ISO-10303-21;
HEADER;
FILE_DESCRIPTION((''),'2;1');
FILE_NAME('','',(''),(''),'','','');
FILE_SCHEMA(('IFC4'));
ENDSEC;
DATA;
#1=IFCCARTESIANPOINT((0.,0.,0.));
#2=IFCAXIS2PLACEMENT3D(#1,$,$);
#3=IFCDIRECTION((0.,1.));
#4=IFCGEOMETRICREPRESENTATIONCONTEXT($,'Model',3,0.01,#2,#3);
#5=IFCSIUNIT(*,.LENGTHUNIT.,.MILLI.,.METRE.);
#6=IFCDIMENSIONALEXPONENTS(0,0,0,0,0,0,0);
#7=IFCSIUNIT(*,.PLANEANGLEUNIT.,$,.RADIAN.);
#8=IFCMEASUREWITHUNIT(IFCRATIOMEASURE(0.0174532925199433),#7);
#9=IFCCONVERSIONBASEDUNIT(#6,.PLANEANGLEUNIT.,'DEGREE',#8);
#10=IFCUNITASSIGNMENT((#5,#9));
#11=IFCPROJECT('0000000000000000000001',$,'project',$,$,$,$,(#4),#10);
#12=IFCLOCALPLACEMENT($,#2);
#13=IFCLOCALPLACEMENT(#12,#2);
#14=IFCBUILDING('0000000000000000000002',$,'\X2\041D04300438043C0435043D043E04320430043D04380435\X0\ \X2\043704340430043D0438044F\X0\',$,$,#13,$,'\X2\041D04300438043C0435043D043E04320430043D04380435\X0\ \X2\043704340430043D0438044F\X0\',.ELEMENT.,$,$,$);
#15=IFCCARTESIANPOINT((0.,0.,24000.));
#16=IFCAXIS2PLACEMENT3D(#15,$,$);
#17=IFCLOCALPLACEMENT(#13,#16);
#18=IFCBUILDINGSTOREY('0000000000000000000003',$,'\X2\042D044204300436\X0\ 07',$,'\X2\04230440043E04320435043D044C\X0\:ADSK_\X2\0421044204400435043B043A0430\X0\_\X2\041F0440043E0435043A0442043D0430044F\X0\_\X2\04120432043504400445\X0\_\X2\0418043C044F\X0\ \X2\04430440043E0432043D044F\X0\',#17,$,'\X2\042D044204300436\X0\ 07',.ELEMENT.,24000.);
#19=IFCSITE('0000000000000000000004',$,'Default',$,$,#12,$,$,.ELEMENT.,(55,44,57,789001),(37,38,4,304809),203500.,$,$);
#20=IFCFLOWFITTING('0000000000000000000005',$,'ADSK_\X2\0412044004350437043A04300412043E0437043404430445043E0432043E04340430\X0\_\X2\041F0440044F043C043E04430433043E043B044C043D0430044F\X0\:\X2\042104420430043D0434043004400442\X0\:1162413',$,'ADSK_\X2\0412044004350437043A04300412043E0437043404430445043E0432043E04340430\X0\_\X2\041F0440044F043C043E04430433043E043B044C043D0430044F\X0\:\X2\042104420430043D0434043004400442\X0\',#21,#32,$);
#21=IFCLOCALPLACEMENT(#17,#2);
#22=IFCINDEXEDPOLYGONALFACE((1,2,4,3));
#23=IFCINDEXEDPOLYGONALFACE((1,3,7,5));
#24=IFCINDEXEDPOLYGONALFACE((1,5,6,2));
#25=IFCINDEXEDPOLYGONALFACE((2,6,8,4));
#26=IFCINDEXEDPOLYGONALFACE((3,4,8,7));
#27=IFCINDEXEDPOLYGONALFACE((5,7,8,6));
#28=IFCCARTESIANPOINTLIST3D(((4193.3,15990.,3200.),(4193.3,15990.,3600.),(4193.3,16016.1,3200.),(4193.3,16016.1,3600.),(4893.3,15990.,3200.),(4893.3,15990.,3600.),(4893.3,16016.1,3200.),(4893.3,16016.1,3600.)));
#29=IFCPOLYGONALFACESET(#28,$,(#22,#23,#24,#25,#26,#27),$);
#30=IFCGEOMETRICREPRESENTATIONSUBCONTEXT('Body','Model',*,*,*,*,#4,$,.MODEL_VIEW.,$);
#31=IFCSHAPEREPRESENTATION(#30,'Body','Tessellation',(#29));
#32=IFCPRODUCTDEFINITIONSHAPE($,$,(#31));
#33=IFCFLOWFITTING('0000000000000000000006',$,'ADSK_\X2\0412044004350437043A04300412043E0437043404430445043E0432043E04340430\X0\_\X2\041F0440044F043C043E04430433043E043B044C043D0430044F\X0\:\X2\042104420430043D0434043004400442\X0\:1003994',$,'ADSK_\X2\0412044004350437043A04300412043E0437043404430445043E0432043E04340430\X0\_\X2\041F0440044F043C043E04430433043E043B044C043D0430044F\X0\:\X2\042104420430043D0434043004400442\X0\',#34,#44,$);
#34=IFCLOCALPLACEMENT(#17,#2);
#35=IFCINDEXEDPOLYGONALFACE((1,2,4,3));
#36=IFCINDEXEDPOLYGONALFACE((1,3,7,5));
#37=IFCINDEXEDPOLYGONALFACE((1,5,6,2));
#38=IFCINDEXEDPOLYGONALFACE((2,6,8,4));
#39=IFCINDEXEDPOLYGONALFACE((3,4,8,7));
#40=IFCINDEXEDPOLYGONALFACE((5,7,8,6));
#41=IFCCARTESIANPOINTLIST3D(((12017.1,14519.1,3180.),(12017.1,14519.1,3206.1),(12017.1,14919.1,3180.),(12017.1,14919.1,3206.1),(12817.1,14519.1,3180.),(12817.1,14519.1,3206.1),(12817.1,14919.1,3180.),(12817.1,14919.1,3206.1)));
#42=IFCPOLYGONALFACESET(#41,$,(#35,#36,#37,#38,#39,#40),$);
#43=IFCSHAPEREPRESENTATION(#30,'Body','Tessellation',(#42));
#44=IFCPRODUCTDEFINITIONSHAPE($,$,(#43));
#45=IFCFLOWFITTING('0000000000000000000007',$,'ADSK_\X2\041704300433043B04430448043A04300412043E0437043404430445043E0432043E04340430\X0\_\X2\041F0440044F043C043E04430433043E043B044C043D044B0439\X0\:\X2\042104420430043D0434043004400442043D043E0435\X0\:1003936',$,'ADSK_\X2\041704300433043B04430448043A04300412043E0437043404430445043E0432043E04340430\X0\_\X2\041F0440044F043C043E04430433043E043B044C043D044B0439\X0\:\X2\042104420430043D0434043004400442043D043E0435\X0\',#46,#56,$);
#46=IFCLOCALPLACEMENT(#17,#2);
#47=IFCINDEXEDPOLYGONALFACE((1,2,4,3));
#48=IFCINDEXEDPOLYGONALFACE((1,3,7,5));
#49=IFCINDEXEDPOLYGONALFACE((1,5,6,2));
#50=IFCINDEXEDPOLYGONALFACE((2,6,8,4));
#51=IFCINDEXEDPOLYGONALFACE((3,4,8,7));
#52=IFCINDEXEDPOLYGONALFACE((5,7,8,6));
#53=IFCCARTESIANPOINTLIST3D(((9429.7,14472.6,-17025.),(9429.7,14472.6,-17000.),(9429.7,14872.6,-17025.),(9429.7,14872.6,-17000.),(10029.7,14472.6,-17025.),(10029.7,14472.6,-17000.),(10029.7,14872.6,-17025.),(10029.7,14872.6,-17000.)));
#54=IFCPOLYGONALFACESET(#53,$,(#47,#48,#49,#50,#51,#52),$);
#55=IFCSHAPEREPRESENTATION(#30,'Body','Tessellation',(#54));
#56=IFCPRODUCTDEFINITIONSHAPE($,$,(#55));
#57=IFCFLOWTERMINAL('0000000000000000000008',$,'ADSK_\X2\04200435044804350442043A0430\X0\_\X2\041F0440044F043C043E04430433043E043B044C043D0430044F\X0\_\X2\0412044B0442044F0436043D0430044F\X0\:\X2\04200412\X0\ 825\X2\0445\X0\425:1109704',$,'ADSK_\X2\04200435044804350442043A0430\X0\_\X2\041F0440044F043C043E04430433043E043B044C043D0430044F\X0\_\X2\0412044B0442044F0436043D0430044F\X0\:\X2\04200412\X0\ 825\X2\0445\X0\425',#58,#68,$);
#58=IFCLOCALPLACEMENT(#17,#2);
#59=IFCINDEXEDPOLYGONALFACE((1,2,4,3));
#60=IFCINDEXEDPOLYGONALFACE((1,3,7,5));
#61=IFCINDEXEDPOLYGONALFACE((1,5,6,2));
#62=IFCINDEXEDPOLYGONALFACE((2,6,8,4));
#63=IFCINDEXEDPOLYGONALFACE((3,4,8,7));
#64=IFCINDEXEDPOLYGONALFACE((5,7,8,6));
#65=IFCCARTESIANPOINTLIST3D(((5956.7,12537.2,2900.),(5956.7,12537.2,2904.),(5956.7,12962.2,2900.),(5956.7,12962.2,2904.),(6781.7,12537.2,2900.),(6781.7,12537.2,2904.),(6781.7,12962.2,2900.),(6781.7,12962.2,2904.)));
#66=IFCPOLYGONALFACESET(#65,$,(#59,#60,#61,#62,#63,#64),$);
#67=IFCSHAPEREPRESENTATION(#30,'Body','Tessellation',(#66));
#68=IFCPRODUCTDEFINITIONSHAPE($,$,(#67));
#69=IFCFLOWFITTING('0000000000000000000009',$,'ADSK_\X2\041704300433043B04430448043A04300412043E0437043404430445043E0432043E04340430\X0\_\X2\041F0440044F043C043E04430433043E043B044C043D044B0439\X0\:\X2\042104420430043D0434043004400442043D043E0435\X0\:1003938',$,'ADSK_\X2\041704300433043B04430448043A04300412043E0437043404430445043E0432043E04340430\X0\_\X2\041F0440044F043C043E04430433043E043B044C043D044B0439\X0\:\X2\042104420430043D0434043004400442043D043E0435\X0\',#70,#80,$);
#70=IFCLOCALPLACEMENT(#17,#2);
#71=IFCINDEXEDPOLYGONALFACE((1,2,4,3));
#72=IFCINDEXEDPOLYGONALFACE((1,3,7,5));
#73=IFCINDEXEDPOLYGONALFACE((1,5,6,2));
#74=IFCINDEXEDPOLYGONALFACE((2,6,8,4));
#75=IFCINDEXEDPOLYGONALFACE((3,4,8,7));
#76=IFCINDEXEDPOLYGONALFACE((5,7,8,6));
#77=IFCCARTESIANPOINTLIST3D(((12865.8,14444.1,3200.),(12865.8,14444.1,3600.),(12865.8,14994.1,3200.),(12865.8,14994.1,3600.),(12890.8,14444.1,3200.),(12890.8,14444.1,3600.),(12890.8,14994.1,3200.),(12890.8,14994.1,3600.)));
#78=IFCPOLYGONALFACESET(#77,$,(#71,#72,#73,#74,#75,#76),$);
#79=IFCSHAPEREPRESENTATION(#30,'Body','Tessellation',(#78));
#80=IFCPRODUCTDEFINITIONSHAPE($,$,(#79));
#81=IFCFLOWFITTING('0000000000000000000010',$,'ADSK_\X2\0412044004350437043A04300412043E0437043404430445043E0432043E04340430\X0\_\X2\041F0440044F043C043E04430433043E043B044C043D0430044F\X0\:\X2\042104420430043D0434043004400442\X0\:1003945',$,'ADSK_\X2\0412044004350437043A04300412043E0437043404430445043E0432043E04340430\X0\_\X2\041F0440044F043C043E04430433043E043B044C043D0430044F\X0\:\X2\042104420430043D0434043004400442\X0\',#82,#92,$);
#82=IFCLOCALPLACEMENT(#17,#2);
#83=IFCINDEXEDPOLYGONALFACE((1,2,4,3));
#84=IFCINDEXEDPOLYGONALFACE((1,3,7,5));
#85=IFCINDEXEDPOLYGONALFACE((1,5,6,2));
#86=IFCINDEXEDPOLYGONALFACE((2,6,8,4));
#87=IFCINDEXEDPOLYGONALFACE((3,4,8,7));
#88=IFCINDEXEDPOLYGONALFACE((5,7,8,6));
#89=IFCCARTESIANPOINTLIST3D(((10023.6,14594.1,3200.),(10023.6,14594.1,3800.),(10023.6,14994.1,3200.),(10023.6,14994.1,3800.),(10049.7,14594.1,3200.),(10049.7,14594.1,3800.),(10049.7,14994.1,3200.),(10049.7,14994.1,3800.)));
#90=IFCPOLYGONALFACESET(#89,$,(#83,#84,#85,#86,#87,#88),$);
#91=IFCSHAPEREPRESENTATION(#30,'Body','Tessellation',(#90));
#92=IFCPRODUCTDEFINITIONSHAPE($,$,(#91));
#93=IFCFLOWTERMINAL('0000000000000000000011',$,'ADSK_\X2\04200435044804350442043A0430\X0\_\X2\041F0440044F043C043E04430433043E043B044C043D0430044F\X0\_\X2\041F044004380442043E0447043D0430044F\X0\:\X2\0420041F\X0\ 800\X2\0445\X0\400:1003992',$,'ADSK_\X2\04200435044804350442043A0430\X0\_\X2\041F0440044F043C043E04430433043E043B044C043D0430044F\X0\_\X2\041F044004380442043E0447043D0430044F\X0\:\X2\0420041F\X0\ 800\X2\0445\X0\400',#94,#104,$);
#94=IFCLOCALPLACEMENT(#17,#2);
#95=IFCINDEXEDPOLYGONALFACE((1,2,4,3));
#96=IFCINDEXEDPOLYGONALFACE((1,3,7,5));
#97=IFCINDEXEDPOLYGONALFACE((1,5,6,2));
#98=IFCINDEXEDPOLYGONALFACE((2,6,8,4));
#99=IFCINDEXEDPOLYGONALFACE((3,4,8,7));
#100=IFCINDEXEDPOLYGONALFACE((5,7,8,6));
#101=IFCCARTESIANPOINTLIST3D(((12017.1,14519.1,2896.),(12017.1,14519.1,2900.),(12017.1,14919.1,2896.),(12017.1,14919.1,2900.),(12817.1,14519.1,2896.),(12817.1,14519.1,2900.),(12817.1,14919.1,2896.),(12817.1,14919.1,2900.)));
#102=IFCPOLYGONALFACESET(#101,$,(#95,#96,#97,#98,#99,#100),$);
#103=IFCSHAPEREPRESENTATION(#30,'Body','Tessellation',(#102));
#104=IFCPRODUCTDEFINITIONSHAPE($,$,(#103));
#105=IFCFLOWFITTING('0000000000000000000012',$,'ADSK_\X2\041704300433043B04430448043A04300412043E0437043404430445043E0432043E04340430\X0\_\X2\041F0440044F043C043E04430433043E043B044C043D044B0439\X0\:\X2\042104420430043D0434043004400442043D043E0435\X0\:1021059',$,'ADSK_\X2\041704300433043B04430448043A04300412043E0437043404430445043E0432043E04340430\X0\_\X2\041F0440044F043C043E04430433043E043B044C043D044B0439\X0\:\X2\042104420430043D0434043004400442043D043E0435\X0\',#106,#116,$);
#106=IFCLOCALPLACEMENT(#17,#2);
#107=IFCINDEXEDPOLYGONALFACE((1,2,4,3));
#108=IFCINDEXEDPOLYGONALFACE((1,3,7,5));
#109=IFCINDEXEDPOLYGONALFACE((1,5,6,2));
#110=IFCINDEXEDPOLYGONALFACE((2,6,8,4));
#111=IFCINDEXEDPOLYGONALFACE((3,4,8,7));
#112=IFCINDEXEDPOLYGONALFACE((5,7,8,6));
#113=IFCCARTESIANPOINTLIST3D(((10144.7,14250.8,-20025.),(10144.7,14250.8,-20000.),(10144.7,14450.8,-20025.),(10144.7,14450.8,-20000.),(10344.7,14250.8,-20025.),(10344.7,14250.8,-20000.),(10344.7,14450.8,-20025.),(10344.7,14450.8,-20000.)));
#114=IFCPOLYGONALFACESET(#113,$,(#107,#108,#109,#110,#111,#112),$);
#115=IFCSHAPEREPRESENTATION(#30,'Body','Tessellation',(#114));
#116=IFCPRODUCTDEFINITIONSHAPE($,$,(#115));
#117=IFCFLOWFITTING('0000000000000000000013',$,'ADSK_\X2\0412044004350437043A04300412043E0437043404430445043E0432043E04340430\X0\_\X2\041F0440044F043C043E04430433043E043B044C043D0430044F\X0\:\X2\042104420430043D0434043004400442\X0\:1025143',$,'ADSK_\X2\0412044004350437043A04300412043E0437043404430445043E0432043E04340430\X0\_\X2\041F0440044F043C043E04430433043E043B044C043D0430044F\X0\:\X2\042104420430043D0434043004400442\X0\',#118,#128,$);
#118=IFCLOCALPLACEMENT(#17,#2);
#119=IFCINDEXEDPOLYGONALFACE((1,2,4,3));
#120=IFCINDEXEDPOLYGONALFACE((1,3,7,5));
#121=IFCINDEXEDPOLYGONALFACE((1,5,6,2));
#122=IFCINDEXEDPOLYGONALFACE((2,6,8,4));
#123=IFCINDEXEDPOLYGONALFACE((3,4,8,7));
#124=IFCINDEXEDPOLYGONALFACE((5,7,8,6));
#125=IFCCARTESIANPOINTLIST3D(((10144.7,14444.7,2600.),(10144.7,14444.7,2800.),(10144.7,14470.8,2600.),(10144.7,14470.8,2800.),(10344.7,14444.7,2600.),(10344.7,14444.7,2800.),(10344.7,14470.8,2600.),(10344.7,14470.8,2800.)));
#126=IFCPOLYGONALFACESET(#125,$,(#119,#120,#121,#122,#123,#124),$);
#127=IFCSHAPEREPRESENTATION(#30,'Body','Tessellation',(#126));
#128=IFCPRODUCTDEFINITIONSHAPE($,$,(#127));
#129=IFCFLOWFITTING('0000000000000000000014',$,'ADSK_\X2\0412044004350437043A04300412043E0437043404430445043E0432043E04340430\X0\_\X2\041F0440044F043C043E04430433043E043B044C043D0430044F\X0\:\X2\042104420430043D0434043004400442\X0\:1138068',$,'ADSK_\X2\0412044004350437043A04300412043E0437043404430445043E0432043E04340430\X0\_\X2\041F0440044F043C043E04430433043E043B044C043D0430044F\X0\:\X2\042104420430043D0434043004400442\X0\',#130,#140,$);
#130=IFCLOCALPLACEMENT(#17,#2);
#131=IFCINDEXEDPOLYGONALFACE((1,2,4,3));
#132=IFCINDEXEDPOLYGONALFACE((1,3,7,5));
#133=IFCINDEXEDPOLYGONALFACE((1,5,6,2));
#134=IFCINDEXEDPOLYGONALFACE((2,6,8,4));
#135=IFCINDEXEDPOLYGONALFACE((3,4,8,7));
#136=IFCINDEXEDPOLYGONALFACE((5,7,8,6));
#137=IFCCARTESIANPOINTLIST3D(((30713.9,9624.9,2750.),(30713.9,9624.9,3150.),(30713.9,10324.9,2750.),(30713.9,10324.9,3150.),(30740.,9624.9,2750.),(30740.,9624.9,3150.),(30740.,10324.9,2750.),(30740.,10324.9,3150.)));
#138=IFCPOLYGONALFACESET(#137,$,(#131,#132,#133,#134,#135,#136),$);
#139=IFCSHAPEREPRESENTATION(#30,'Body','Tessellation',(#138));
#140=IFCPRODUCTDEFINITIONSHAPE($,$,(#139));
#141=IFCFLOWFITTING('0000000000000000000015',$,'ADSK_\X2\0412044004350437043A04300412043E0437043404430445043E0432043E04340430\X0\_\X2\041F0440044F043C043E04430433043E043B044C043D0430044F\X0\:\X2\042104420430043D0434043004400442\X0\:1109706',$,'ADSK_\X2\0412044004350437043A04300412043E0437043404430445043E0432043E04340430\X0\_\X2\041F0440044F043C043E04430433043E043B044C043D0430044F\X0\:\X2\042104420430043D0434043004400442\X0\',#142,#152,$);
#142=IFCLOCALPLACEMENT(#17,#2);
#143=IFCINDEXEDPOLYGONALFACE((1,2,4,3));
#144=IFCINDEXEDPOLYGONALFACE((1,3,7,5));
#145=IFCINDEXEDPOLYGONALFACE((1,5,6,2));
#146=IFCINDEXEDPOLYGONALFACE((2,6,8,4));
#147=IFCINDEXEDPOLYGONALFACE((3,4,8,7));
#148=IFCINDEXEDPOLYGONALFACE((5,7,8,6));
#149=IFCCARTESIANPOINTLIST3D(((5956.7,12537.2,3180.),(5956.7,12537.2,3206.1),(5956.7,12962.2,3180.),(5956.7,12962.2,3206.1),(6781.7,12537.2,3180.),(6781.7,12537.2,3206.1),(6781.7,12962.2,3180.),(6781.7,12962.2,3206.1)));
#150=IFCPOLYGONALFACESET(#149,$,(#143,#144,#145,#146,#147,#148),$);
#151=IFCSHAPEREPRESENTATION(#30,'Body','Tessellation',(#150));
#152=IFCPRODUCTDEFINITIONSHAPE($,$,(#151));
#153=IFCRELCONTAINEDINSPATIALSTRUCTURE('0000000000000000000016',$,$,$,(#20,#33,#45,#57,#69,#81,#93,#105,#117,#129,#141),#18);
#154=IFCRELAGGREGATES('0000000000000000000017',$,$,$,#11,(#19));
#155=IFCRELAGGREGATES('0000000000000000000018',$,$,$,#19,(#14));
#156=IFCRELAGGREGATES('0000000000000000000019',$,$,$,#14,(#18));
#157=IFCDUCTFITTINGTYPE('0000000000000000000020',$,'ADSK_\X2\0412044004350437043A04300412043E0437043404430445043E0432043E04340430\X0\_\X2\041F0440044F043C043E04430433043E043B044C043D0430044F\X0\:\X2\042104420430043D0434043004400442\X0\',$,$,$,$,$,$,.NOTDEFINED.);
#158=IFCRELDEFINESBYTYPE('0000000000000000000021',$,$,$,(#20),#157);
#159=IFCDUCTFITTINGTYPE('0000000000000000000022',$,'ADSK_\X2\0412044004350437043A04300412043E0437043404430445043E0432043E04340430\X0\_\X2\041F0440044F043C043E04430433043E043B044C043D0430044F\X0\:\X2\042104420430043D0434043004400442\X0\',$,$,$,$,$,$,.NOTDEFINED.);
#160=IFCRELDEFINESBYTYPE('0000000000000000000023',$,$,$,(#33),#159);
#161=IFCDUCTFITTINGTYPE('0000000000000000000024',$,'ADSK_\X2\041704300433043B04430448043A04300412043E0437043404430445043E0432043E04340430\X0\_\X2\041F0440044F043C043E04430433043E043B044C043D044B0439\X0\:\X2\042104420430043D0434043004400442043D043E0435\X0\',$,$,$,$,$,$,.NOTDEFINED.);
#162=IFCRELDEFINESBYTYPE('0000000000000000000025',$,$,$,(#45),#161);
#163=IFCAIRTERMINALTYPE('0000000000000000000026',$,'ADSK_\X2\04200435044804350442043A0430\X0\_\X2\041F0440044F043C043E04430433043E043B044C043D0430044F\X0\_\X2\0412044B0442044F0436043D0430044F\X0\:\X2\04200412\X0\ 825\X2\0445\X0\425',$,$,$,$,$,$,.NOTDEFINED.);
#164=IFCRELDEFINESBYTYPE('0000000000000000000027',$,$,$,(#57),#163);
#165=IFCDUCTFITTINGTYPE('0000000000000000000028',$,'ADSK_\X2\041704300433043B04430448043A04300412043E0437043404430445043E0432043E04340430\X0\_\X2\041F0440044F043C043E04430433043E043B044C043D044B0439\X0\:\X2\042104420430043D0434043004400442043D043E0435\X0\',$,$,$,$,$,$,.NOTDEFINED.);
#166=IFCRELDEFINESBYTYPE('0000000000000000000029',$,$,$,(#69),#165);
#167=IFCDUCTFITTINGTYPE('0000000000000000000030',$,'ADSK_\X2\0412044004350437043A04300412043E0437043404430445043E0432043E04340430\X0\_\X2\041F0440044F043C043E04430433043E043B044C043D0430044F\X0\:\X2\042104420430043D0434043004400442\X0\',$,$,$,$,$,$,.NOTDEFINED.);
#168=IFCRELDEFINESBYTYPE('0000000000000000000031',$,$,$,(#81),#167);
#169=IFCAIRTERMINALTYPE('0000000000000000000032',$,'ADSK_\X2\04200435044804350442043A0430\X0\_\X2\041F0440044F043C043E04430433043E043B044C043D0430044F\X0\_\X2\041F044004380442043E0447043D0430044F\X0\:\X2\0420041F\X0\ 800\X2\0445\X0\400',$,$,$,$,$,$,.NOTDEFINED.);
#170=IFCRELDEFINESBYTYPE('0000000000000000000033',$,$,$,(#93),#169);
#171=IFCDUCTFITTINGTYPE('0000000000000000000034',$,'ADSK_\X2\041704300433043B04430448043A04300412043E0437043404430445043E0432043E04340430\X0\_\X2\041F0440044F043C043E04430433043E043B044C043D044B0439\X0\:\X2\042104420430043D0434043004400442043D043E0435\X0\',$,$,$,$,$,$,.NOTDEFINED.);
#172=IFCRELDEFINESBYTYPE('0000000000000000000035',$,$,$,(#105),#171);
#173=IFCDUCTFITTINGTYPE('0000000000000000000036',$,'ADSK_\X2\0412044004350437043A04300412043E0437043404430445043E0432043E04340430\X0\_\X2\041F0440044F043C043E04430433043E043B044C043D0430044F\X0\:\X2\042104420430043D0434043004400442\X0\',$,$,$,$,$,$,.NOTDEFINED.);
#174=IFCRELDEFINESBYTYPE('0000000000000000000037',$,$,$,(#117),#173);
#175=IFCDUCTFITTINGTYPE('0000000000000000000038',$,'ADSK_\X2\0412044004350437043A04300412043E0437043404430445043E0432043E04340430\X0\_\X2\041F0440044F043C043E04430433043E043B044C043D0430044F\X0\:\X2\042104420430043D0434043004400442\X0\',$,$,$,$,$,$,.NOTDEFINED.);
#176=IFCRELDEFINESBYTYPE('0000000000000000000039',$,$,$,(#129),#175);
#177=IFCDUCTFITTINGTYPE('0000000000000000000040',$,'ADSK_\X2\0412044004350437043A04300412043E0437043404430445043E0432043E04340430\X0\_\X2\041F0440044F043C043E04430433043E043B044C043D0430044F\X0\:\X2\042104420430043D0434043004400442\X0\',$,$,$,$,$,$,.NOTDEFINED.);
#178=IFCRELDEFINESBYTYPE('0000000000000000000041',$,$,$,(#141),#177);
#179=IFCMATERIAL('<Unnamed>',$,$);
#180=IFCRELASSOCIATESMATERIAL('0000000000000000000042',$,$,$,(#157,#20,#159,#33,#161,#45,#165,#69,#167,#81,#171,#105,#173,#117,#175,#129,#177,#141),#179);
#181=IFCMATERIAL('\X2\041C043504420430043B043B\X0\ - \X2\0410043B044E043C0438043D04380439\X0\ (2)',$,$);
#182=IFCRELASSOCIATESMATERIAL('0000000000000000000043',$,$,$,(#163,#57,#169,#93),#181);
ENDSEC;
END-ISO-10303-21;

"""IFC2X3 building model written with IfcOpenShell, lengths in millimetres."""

from ifc_helpers import new_model, entity, si_unit, converted_unit, direction, frame, origin, origin_2d_with_axis, place, context, subcontext, project, spatial, rectangle, extrude, source, transform, mapped, material, type_object, type_shapes, element, save


model = new_model("IFC2X3")

# Units and contexts
model_context = context("Model", 3, precision=0.01, world=origin(), true_north=direction((0.0, 1.0)))
body_context = subcontext(model_context, "Body", "Model", "MODEL_VIEW")
ifc_project = project(units=[si_unit("LENGTHUNIT", "METRE", prefix="MILLI"), converted_unit("PLANEANGLEUNIT", "DEGREE", entity("IfcRatioMeasure", 0.0174532925199433), si_unit("PLANEANGLEUNIT", "RADIAN"), dimensions=[0, 0, 0, 0, 0, 0, 0])], contexts=[model_context])

# Site, building, storey
site_placement = place(None, origin())
site = spatial("IfcSite", under=ifc_project, at=site_placement, Name="Default", CompositionType="ELEMENT", RefLatitude=(55, 44, 57, 789001), RefLongitude=(37, 38, 4, 304809), RefElevation=203500.0)
building_placement = place(site_placement, origin())
building = spatial("IfcBuilding", under=site, at=building_placement, Name="Наименование здания", LongName="Наименование здания", CompositionType="ELEMENT")
storey_placement = place(building_placement, frame((0.0, 0.0, 24000.0)))
storey = spatial("IfcBuildingStorey", under=building, at=storey_placement, Name="Этаж 07", ObjectType="Уровень:ADSK_Стрелка_Проектная_Вверх_Имя уровня", LongName="Этаж 07", CompositionType="ELEMENT", Elevation=24000.0)

# Flow fittings
ifc_material_1 = material(Name="<Unnamed>")
duct_fitting_type_1 = type_object("IfcDuctFittingType", Name="ADSK_ВрезкаВоздуховода_Прямоугольная:Стандарт", PredefinedType="NOTDEFINED", material=ifc_material_1)
shared_shape_1 = source(origin(), body_context, "Body", "SweptSolid", [
    extrude(rectangle(XDim=26.1, YDim=400.0, at=origin_2d_with_axis()), frame((7.0, 0.0, -350.0)), (0.0, 0.0, 1.0), 700.0),
])
type_shapes(duct_fitting_type_1, [shared_shape_1])
flow_fitting_1_placement = place(storey_placement, frame((4543.3, 16010.0, 3400.0), z_axis=(-1.0, 0.0, 0.0), x_axis=(0.0, -1.0, 0.0)))
element("IfcFlowFitting", 1, at=flow_fitting_1_placement, inside=storey, type_object=duct_fitting_type_1, material=ifc_material_1, Name="ADSK_ВрезкаВоздуховода_Прямоугольная:Стандарт:1162413", ObjectType="ADSK_ВрезкаВоздуховода_Прямоугольная:Стандарт", context=body_context, shape_type="MappedRepresentation", body=[
    mapped(shared_shape_1, transform((0.0, 0.0, 0.0), scale=1.0)),
])
duct_fitting_type_2 = type_object("IfcDuctFittingType", Name="ADSK_ВрезкаВоздуховода_Прямоугольная:Стандарт", PredefinedType="NOTDEFINED", material=ifc_material_1)
shared_shape_2 = source(origin(), body_context, "Body", "SweptSolid", [
    extrude(rectangle(XDim=800.0, YDim=26.1, at=origin_2d_with_axis()), frame((7.0, 0.0, -200.0), z_axis=(0.0, 0.0, 1.0), x_axis=(0.0, -1.0, 0.0)), (0.0, 0.0, 1.0), 400.0),
])
type_shapes(duct_fitting_type_2, [shared_shape_2])
flow_fitting_2_placement = place(storey_placement, frame((12417.1, 14719.1, 3200.0), z_axis=(0.0, 1.0, 0.0), x_axis=(0.0, 0.0, -1.0)))
element("IfcFlowFitting", 2, at=flow_fitting_2_placement, inside=storey, type_object=duct_fitting_type_2, material=ifc_material_1, Name="ADSK_ВрезкаВоздуховода_Прямоугольная:Стандарт:1003994", ObjectType="ADSK_ВрезкаВоздуховода_Прямоугольная:Стандарт", context=body_context, shape_type="MappedRepresentation", body=[
    mapped(shared_shape_2, transform((0.0, 0.0, 0.0), scale=1.0)),
])
duct_fitting_type_3 = type_object("IfcDuctFittingType", Name="ADSK_ЗаглушкаВоздуховода_Прямоугольный:Стандартное", PredefinedType="NOTDEFINED", material=ifc_material_1)
shared_shape_3 = source(origin(), body_context, "Body", "SweptSolid", [
    extrude(rectangle(XDim=25.0, YDim=600.0, at=origin_2d_with_axis()), frame((12.5, 0.0, -200.0)), (0.0, 0.0, 1.0), 400.0),
])
type_shapes(duct_fitting_type_3, [shared_shape_3])
flow_fitting_3_placement = place(storey_placement, frame((9729.7, 14672.6, -17000.0), z_axis=(0.0, -1.0, 0.0), x_axis=(0.0, 0.0, -1.0)))
element("IfcFlowFitting", 3, at=flow_fitting_3_placement, inside=storey, type_object=duct_fitting_type_3, material=ifc_material_1, Name="ADSK_ЗаглушкаВоздуховода_Прямоугольный:Стандартное:1003936", ObjectType="ADSK_ЗаглушкаВоздуховода_Прямоугольный:Стандартное", context=body_context, shape_type="MappedRepresentation", body=[
    mapped(shared_shape_3, transform((0.0, 0.0, 0.0), scale=1.0)),
])

# Flow terminal
ifc_material_2 = material(Name="Металл - Алюминий (2)")
air_terminal_type_1 = type_object("IfcAirTerminalType", Name="ADSK_Решетка_Прямоугольная_Вытяжная:РВ 825х425", PredefinedType="NOTDEFINED", material=ifc_material_2)
shared_shape_4 = source(origin(), body_context, "Body", "SweptSolid", [
    extrude(rectangle(XDim=4.0, YDim=825.0, at=origin_2d_with_axis()), frame((0.0, -2.0, -212.5), z_axis=(0.0, 0.0, 1.0), x_axis=(0.0, 1.0, 0.0)), (0.0, 0.0, 1.0), 425.0),
])
type_shapes(air_terminal_type_1, [shared_shape_4])
flow_terminal_1_placement = place(storey_placement, frame((6369.2, 12749.7, 2904.0), z_axis=(0.0, 1.0, 0.0), x_axis=(-1.0, 0.0, 0.0)))
element("IfcFlowTerminal", 4, at=flow_terminal_1_placement, inside=storey, type_object=air_terminal_type_1, material=ifc_material_2, Name="ADSK_Решетка_Прямоугольная_Вытяжная:РВ 825х425:1109704", ObjectType="ADSK_Решетка_Прямоугольная_Вытяжная:РВ 825х425", context=body_context, shape_type="MappedRepresentation", body=[
    mapped(shared_shape_4, transform((0.0, 0.0, 0.0), scale=1.0)),
])

# Flow fittings
duct_fitting_type_4 = type_object("IfcDuctFittingType", Name="ADSK_ЗаглушкаВоздуховода_Прямоугольный:Стандартное", PredefinedType="NOTDEFINED", material=ifc_material_1)
shared_shape_5 = source(origin(), body_context, "Body", "SweptSolid", [
    extrude(rectangle(XDim=25.0, YDim=550.0, at=origin_2d_with_axis()), frame((12.5, 0.0, -200.0)), (0.0, 0.0, 1.0), 400.0),
])
type_shapes(duct_fitting_type_4, [shared_shape_5])
flow_fitting_4_placement = place(storey_placement, frame((12865.8, 14719.1, 3400.0)))
element("IfcFlowFitting", 5, at=flow_fitting_4_placement, inside=storey, type_object=duct_fitting_type_4, material=ifc_material_1, Name="ADSK_ЗаглушкаВоздуховода_Прямоугольный:Стандартное:1003938", ObjectType="ADSK_ЗаглушкаВоздуховода_Прямоугольный:Стандартное", context=body_context, shape_type="MappedRepresentation", body=[
    mapped(shared_shape_5, transform((0.0, 0.0, 0.0), scale=1.0)),
])
duct_fitting_type_5 = type_object("IfcDuctFittingType", Name="ADSK_ВрезкаВоздуховода_Прямоугольная:Стандарт", PredefinedType="NOTDEFINED", material=ifc_material_1)
shared_shape_6 = source(origin(), body_context, "Body", "SweptSolid", [
    extrude(rectangle(XDim=600.0, YDim=26.1, at=origin_2d_with_axis()), frame((7.0, 0.0, -200.0), z_axis=(0.0, 0.0, 1.0), x_axis=(0.0, -1.0, 0.0)), (0.0, 0.0, 1.0), 400.0),
])
type_shapes(duct_fitting_type_5, [shared_shape_6])
flow_fitting_5_placement = place(storey_placement, frame((10029.7, 14794.1, 3500.0), z_axis=(0.0, -1.0, 0.0), x_axis=(1.0, 0.0, 0.0)))
element("IfcFlowFitting", 6, at=flow_fitting_5_placement, inside=storey, type_object=duct_fitting_type_5, material=ifc_material_1, Name="ADSK_ВрезкаВоздуховода_Прямоугольная:Стандарт:1003945", ObjectType="ADSK_ВрезкаВоздуховода_Прямоугольная:Стандарт", context=body_context, shape_type="MappedRepresentation", body=[
    mapped(shared_shape_6, transform((0.0, 0.0, 0.0), scale=1.0)),
])

# Flow terminal
air_terminal_type_2 = type_object("IfcAirTerminalType", Name="ADSK_Решетка_Прямоугольная_Приточная:РП 800х400", PredefinedType="NOTDEFINED", material=ifc_material_2)
shared_shape_7 = source(origin(), body_context, "Body", "SweptSolid", [
    extrude(rectangle(XDim=4.0, YDim=800.0, at=origin_2d_with_axis()), frame((0.0, -2.0, -200.0), z_axis=(0.0, 0.0, 1.0), x_axis=(0.0, 1.0, 0.0)), (0.0, 0.0, 1.0), 400.0),
])
type_shapes(air_terminal_type_2, [shared_shape_7])
flow_terminal_2_placement = place(storey_placement, frame((12417.1, 14719.1, 2900.0), z_axis=(0.0, 1.0, 0.0), x_axis=(-1.0, 0.0, 0.0)))
element("IfcFlowTerminal", 7, at=flow_terminal_2_placement, inside=storey, type_object=air_terminal_type_2, material=ifc_material_2, Name="ADSK_Решетка_Прямоугольная_Приточная:РП 800х400:1003992", ObjectType="ADSK_Решетка_Прямоугольная_Приточная:РП 800х400", context=body_context, shape_type="MappedRepresentation", body=[
    mapped(shared_shape_7, transform((0.0, 0.0, 0.0), scale=1.0)),
])

# Flow fittings
duct_fitting_type_6 = type_object("IfcDuctFittingType", Name="ADSK_ЗаглушкаВоздуховода_Прямоугольный:Стандартное", PredefinedType="NOTDEFINED", material=ifc_material_1)
shared_shape_8 = source(origin(), body_context, "Body", "SweptSolid", [
    extrude(rectangle(XDim=25.0, YDim=200.0, at=origin_2d_with_axis()), frame((12.5, 0.0, -100.0)), (0.0, 0.0, 1.0), 200.0),
])
type_shapes(duct_fitting_type_6, [shared_shape_8])
flow_fitting_6_placement = place(storey_placement, frame((10244.7, 14350.8, -20000.0), z_axis=(0.0, -1.0, 0.0), x_axis=(0.0, 0.0, -1.0)))
element("IfcFlowFitting", 8, at=flow_fitting_6_placement, inside=storey, type_object=duct_fitting_type_6, material=ifc_material_1, Name="ADSK_ЗаглушкаВоздуховода_Прямоугольный:Стандартное:1021059", ObjectType="ADSK_ЗаглушкаВоздуховода_Прямоугольный:Стандартное", context=body_context, shape_type="MappedRepresentation", body=[
    mapped(shared_shape_8, transform((0.0, 0.0, 0.0), scale=1.0)),
])
duct_fitting_type_7 = type_object("IfcDuctFittingType", Name="ADSK_ВрезкаВоздуховода_Прямоугольная:Стандарт", PredefinedType="NOTDEFINED", material=ifc_material_1)
shared_shape_9 = source(origin(), body_context, "Body", "SweptSolid", [
    extrude(rectangle(XDim=200.0, YDim=26.1, at=origin_2d_with_axis()), frame((7.0, 0.0, -100.0), z_axis=(0.0, 0.0, 1.0), x_axis=(0.0, -1.0, 0.0)), (0.0, 0.0, 1.0), 200.0),
])
type_shapes(duct_fitting_type_7, [shared_shape_9])
flow_fitting_7_placement = place(storey_placement, frame((10244.7, 14450.8, 2700.0), z_axis=(1.0, 0.0, 0.0), x_axis=(0.0, 1.0, 0.0)))
element("IfcFlowFitting", 9, at=flow_fitting_7_placement, inside=storey, type_object=duct_fitting_type_7, material=ifc_material_1, Name="ADSK_ВрезкаВоздуховода_Прямоугольная:Стандарт:1025143", ObjectType="ADSK_ВрезкаВоздуховода_Прямоугольная:Стандарт", context=body_context, shape_type="MappedRepresentation", body=[
    mapped(shared_shape_9, transform((0.0, 0.0, 0.0), scale=1.0)),
])
duct_fitting_type_8 = type_object("IfcDuctFittingType", Name="ADSK_ВрезкаВоздуховода_Прямоугольная:Стандарт", PredefinedType="NOTDEFINED", material=ifc_material_1)
shared_shape_10 = source(origin(), body_context, "Body", "SweptSolid", [
    extrude(rectangle(XDim=700.0, YDim=26.1, at=origin_2d_with_axis()), frame((7.0, 0.0, -200.0), z_axis=(0.0, 0.0, 1.0), x_axis=(0.0, -1.0, 0.0)), (0.0, 0.0, 1.0), 400.0),
])
type_shapes(duct_fitting_type_8, [shared_shape_10])
flow_fitting_8_placement = place(storey_placement, frame((30720.0, 9974.9, 2950.0), z_axis=(0.0, 0.0, -1.0), x_axis=(1.0, 0.0, 0.0)))
element("IfcFlowFitting", 10, at=flow_fitting_8_placement, inside=storey, type_object=duct_fitting_type_8, material=ifc_material_1, Name="ADSK_ВрезкаВоздуховода_Прямоугольная:Стандарт:1138068", ObjectType="ADSK_ВрезкаВоздуховода_Прямоугольная:Стандарт", context=body_context, shape_type="MappedRepresentation", body=[
    mapped(shared_shape_10, transform((0.0, 0.0, 0.0), scale=1.0)),
])
duct_fitting_type_9 = type_object("IfcDuctFittingType", Name="ADSK_ВрезкаВоздуховода_Прямоугольная:Стандарт", PredefinedType="NOTDEFINED", material=ifc_material_1)
shared_shape_11 = source(origin(), body_context, "Body", "SweptSolid", [
    extrude(rectangle(XDim=825.0, YDim=26.1, at=origin_2d_with_axis()), frame((7.0, 0.0, -212.5), z_axis=(0.0, 0.0, 1.0), x_axis=(0.0, -1.0, 0.0)), (0.0, 0.0, 1.0), 425.0),
])
type_shapes(duct_fitting_type_9, [shared_shape_11])
flow_fitting_9_placement = place(storey_placement, frame((6369.2, 12749.7, 3200.0), z_axis=(0.0, -1.0, 0.0), x_axis=(0.0, 0.0, -1.0)))
element("IfcFlowFitting", 11, at=flow_fitting_9_placement, inside=storey, type_object=duct_fitting_type_9, material=ifc_material_1, Name="ADSK_ВрезкаВоздуховода_Прямоугольная:Стандарт:1109706", ObjectType="ADSK_ВрезкаВоздуховода_Прямоугольная:Стандарт", context=body_context, shape_type="MappedRepresentation", body=[
    mapped(shared_shape_11, transform((0.0, 0.0, 0.0), scale=1.0)),
])

save(model, "model.ifc")
